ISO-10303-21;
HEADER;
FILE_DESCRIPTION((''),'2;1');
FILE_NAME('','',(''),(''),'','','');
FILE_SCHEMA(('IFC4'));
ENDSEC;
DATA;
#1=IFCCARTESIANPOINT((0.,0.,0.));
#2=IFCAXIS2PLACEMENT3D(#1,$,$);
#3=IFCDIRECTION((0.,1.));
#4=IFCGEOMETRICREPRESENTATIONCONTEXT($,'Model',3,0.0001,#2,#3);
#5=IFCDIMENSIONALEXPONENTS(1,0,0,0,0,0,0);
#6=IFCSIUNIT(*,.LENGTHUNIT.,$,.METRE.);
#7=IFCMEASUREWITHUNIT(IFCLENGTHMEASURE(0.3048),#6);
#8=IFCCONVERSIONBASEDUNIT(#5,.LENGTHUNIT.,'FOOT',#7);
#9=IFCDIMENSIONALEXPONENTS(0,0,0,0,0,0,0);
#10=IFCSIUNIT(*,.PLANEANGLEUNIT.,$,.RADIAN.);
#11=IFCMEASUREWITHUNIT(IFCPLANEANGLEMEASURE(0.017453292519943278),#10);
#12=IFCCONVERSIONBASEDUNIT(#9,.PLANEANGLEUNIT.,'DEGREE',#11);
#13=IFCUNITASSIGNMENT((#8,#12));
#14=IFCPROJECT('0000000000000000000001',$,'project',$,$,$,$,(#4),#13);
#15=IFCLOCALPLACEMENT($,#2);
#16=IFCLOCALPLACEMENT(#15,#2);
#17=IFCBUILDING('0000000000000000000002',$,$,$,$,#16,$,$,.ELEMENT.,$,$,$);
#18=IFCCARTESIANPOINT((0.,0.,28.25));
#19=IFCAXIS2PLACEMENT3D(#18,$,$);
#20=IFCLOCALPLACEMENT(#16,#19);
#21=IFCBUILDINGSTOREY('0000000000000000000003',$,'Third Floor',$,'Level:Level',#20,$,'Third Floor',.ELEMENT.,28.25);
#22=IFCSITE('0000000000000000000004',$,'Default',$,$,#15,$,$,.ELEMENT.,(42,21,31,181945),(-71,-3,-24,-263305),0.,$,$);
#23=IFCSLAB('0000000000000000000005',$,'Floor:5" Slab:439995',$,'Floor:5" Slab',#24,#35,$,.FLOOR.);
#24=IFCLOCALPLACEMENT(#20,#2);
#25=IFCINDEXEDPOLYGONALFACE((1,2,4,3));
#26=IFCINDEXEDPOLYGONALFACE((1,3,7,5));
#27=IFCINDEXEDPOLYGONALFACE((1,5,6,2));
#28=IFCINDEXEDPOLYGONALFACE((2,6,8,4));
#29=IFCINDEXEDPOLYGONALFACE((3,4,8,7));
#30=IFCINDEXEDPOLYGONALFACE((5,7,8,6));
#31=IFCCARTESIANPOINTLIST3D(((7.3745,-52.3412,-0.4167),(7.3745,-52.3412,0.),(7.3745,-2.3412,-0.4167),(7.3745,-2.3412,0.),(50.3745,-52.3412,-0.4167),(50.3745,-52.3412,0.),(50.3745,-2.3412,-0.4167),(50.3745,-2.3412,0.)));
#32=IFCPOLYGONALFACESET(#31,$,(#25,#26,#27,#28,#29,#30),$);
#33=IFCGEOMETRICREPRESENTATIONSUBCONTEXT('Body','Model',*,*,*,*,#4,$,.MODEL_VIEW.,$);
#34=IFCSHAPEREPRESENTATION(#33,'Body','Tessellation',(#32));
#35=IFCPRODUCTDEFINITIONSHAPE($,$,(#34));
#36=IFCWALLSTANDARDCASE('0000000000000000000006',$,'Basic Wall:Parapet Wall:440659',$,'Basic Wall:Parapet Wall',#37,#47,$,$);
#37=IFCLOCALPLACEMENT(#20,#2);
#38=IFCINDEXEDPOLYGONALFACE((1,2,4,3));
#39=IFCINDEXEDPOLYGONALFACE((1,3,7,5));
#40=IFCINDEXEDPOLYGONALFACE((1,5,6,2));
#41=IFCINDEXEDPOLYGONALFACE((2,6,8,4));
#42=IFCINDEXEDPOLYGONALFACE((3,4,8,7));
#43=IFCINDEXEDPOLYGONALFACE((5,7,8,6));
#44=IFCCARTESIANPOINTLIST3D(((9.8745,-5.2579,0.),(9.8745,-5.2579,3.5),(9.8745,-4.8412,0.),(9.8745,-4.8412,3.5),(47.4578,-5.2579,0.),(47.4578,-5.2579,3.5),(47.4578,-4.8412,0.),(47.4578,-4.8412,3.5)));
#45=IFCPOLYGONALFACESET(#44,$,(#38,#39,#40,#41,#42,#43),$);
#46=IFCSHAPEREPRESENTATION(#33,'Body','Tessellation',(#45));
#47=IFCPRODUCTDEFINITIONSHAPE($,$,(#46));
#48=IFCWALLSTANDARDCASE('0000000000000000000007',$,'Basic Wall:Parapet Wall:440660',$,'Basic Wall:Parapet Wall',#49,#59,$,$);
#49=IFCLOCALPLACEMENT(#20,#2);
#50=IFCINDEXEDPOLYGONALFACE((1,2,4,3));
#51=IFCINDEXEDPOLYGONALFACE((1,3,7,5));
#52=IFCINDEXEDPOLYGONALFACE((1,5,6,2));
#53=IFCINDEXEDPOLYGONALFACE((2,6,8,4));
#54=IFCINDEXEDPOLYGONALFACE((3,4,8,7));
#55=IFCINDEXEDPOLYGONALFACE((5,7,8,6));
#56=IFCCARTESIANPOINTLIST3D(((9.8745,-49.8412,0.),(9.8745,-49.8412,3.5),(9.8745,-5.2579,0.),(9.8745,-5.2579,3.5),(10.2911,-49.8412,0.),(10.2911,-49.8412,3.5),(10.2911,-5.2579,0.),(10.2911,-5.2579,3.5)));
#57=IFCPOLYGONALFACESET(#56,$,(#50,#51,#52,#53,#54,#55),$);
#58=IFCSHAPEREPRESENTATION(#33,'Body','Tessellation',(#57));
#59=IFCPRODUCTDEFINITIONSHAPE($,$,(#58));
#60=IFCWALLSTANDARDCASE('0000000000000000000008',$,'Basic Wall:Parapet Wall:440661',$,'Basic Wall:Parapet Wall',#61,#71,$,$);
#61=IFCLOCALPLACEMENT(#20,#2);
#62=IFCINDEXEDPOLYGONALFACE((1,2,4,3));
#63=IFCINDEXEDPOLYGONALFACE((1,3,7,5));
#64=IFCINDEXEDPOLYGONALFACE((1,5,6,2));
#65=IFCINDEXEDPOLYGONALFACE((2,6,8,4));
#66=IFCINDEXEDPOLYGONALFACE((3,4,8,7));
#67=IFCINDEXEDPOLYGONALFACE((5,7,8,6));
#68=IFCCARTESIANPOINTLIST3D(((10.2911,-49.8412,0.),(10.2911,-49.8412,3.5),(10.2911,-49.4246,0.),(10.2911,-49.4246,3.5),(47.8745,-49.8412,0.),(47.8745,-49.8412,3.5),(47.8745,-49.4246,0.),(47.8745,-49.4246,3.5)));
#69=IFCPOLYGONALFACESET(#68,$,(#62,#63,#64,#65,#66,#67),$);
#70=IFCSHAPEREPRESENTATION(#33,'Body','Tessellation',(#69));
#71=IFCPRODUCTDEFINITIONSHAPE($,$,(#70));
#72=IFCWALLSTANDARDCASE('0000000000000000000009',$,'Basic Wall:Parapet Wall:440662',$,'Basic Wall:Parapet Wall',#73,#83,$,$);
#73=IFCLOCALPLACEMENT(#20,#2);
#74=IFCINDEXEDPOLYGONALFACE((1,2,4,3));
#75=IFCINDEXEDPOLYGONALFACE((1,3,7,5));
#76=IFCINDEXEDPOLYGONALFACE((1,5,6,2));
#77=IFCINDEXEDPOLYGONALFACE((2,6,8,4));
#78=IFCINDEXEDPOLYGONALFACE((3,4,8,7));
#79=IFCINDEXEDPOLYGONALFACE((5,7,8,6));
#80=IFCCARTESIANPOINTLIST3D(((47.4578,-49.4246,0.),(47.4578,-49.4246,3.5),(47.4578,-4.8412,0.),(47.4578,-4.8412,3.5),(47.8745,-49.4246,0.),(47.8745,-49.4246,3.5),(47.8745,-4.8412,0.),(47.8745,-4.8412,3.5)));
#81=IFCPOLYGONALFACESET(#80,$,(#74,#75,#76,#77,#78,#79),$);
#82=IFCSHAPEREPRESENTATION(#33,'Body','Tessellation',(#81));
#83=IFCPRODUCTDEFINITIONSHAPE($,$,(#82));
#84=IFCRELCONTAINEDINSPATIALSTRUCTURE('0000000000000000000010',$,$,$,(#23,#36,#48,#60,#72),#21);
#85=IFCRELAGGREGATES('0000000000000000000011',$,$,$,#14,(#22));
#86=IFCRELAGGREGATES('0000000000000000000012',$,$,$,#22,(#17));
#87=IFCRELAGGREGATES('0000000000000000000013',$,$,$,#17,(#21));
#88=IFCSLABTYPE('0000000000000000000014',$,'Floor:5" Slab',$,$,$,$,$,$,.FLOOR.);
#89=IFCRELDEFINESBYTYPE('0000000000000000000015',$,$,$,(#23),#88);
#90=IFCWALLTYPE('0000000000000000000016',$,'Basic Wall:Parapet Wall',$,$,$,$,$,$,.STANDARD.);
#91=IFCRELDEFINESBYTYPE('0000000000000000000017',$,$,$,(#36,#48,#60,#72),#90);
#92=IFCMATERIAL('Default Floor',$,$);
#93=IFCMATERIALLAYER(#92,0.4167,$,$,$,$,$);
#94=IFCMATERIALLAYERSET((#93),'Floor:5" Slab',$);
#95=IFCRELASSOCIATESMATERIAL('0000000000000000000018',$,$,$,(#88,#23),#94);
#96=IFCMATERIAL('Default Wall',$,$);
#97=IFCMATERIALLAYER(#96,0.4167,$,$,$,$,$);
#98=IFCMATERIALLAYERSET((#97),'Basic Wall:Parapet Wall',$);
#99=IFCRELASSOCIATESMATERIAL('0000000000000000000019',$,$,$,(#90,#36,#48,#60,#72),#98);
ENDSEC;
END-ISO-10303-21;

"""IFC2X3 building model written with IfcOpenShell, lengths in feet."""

from ifc_helpers import new_model, entity, si_unit, converted_unit, direction, frame, frame_2d, origin, origin_2d_with_axis, place, context, subcontext, project, spatial, rectangle, extrude, material, layer, layer_set, layer_usage, type_object, element, save


model = new_model("IFC2X3")

# Units and contexts
model_context = context("Model", 3, precision=0.0001, world=origin(), true_north=direction((0.0, 1.0)))
body_context = subcontext(model_context, "Body", "Model", "MODEL_VIEW")
ifc_project = project(units=[converted_unit("LENGTHUNIT", "FOOT", entity("IfcLengthMeasure", 0.3048), si_unit("LENGTHUNIT", "METRE"), dimensions=[1, 0, 0, 0, 0, 0, 0]), converted_unit("PLANEANGLEUNIT", "DEGREE", entity("IfcPlaneAngleMeasure", 0.017453292519943278), si_unit("PLANEANGLEUNIT", "RADIAN"), dimensions=[0, 0, 0, 0, 0, 0, 0])], contexts=[model_context])

# Site, building, storey
site_placement = place(None, origin())
site = spatial("IfcSite", under=ifc_project, at=site_placement, Name="Default", CompositionType="ELEMENT", RefLatitude=(42, 21, 31, 181945), RefLongitude=(-71, -3, -24, -263305), RefElevation=0.0)
building_placement = place(site_placement, origin())
building = spatial("IfcBuilding", under=site, at=building_placement, CompositionType="ELEMENT")
storey_placement = place(building_placement, frame((0.0, 0.0, 28.25)))
storey = spatial("IfcBuildingStorey", under=building, at=storey_placement, Name="Third Floor", ObjectType="Level:Level", LongName="Third Floor", CompositionType="ELEMENT", Elevation=28.25)

# Slab
ifc_material_1 = material(Name="Default Floor")
ifc_layer_1 = layer(ifc_material_1, 0.4167)
ifc_layer_set_1 = layer_set([ifc_layer_1], Name="Floor:5\" Slab")
ifc_layer_usage_1 = layer_usage(ifc_layer_set_1, "AXIS3", "POSITIVE", 0.0)
slab_type = type_object("IfcSlabType", Name="Floor:5\" Slab", PredefinedType="FLOOR", material=ifc_layer_set_1)
slab_placement = place(storey_placement, origin())
element("IfcSlab", 1, at=slab_placement, inside=storey, type_object=slab_type, material=ifc_layer_usage_1, Name="Floor:5\" Slab:439995", ObjectType="Floor:5\" Slab", PredefinedType="FLOOR", context=body_context, shape_type="SweptSolid", body=[
    extrude(rectangle(XDim=50.0, YDim=43.0, at=origin_2d_with_axis()), frame((28.8745, -27.3412, 0.0), z_axis=(0.0, 0.0, -1.0), x_axis=(0.0, 1.0, 0.0)), (0.0, 0.0, 1.0), 0.4167),
])

# Walls
ifc_material_2 = material(Name="Default Wall")
ifc_layer_2 = layer(ifc_material_2, 0.4167)
ifc_layer_set_2 = layer_set([ifc_layer_2], Name="Basic Wall:Parapet Wall")
ifc_layer_usage_2 = layer_usage(ifc_layer_set_2, "AXIS2", "NEGATIVE", 0.2083)
wall_type = type_object("IfcWallType", Name="Basic Wall:Parapet Wall", PredefinedType="STANDARD", material=ifc_layer_set_2)
wall_1_placement = place(storey_placement, frame((9.8745, -5.0496, 0.0)))
element("IfcWallStandardCase", 2, at=wall_1_placement, inside=storey, type_object=wall_type, material=ifc_layer_usage_2, Name="Basic Wall:Parapet Wall:440659", ObjectType="Basic Wall:Parapet Wall", context=body_context, shape_type="SweptSolid", body=[
    extrude(rectangle(XDim=37.5833, YDim=0.4167, at=frame_2d((18.7917, 0.0), x_axis=(-1.0, 0.0))), origin(), (0.0, 0.0, 1.0), 3.5),
])
wall_2_placement = place(storey_placement, frame((10.0828, -49.8412, 0.0), z_axis=(0.0, 0.0, 1.0), x_axis=(0.0, 1.0, 0.0)))
element("IfcWallStandardCase", 3, at=wall_2_placement, inside=storey, type_object=wall_type, material=ifc_layer_usage_2, Name="Basic Wall:Parapet Wall:440660", ObjectType="Basic Wall:Parapet Wall", context=body_context, shape_type="SweptSolid", body=[
    extrude(rectangle(XDim=44.5833, YDim=0.4167, at=frame_2d((22.2917, 0.0), x_axis=(-1.0, 0.0))), origin(), (0.0, 0.0, 1.0), 3.5),
])
wall_3_placement = place(storey_placement, frame((47.8745, -49.6329, 0.0), z_axis=(0.0, 0.0, 1.0), x_axis=(-1.0, 0.0, 0.0)))
element("IfcWallStandardCase", 4, at=wall_3_placement, inside=storey, type_object=wall_type, material=ifc_layer_usage_2, Name="Basic Wall:Parapet Wall:440661", ObjectType="Basic Wall:Parapet Wall", context=body_context, shape_type="SweptSolid", body=[
    extrude(rectangle(XDim=37.5833, YDim=0.4167, at=frame_2d((18.7917, 0.0), x_axis=(-1.0, 0.0))), origin(), (0.0, 0.0, 1.0), 3.5),
])
wall_4_placement = place(storey_placement, frame((47.6661, -4.8412, 0.0), z_axis=(0.0, 0.0, 1.0), x_axis=(0.0, -1.0, 0.0)))
element("IfcWallStandardCase", 5, at=wall_4_placement, inside=storey, type_object=wall_type, material=ifc_layer_usage_2, Name="Basic Wall:Parapet Wall:440662", ObjectType="Basic Wall:Parapet Wall", context=body_context, shape_type="SweptSolid", body=[
    extrude(rectangle(XDim=44.5833, YDim=0.4167, at=frame_2d((22.2917, 0.0), x_axis=(-1.0, 0.0))), origin(), (0.0, 0.0, 1.0), 3.5),
])

save(model, "model.ifc")
